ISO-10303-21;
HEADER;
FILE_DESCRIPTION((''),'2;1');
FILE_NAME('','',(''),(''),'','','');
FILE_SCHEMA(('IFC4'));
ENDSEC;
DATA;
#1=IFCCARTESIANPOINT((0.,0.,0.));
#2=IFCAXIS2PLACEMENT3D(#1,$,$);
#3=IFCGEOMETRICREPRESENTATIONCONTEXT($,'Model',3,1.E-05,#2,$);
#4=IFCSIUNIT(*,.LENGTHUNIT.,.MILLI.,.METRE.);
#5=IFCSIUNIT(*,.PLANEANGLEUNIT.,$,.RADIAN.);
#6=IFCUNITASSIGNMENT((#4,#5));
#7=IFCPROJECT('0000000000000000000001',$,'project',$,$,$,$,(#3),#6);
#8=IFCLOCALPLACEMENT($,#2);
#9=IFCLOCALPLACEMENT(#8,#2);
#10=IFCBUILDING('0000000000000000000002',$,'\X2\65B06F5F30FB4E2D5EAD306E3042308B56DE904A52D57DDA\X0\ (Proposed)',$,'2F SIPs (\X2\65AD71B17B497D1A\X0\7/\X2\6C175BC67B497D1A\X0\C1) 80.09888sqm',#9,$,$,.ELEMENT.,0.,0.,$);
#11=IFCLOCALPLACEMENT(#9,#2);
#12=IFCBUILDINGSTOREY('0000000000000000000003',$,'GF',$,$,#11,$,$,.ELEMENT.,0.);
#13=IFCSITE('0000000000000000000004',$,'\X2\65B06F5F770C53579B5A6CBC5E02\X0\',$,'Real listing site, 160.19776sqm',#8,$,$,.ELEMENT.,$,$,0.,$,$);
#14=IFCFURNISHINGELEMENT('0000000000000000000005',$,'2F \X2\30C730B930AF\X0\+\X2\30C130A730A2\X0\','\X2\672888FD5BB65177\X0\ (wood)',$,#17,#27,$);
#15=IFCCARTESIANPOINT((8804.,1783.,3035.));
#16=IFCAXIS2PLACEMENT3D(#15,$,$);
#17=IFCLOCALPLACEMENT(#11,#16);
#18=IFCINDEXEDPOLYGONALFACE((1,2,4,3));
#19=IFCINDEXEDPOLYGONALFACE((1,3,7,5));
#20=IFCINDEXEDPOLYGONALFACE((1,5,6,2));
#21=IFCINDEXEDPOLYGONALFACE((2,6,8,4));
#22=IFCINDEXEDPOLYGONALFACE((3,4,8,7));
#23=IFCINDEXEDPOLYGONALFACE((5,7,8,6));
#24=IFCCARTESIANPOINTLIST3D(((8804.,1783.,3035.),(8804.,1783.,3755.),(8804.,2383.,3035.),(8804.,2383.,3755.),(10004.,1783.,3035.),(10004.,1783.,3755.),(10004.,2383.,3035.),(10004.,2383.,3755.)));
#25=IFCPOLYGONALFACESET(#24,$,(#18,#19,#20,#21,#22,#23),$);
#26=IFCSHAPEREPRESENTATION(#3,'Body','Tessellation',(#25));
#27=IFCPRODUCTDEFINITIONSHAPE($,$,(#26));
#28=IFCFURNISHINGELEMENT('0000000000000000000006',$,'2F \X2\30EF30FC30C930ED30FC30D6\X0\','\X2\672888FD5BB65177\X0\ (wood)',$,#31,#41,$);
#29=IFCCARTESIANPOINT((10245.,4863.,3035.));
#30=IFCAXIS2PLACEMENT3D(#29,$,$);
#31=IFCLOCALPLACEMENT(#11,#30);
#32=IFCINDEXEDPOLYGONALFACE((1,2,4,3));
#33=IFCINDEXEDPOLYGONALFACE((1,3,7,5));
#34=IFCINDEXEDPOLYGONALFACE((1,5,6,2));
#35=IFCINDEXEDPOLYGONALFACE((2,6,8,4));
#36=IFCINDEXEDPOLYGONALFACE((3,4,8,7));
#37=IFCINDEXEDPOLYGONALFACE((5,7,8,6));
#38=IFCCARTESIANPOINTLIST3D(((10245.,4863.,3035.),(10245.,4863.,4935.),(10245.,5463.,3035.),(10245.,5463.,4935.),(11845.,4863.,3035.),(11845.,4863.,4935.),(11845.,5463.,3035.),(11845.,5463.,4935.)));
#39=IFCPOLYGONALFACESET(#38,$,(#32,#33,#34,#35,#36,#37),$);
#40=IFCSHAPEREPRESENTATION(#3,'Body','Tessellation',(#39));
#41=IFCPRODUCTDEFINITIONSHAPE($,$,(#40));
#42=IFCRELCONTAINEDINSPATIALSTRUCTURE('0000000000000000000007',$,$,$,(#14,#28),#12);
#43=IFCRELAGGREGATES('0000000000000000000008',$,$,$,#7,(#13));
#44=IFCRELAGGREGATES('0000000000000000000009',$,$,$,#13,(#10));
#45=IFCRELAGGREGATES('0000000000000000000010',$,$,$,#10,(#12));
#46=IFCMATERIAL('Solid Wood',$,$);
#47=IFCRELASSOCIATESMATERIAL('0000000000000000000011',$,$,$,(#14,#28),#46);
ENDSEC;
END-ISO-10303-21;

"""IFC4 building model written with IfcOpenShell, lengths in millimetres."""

from ifc_helpers import new_model, si_unit, frame, frame_2d, origin, place, context, project, spatial, rectangle, extrude, material, element, save


model = new_model("IFC4")

# Units and contexts
model_context = context("Model", 3, precision=1e-05, world=origin())
ifc_project = project(units=[si_unit("LENGTHUNIT", "METRE", prefix="MILLI"), si_unit("PLANEANGLEUNIT", "RADIAN")], contexts=[model_context])

# Site, building, storey
site_placement = place(None, origin())
site = spatial("IfcSite", under=ifc_project, at=site_placement, Name="新潟県南魚沼市", ObjectType="Real listing site, 160.19776sqm", CompositionType="ELEMENT", RefElevation=0.0)
building_placement = place(site_placement, origin())
building = spatial("IfcBuilding", under=site, at=building_placement, Name="新潟・中庭のある回遊動線 (Proposed)", ObjectType="2F SIPs (断熱等級7/気密等級C1) 80.09888sqm", CompositionType="ELEMENT", ElevationOfRefHeight=0.0, ElevationOfTerrain=0.0)
storey_placement = place(building_placement, origin())
storey = spatial("IfcBuildingStorey", under=building, at=storey_placement, Name="GF", CompositionType="ELEMENT", Elevation=0.0)

# Shared definitions
ifc_material_1 = material(Name="Solid Wood")

# Furnishing elements
furnishing_1_placement = place(storey_placement, frame((8804.0, 1783.0, 3035.0)))
element("IfcFurnishingElement", 1, at=furnishing_1_placement, inside=storey, material=ifc_material_1, Name="2F デスク+チェア", Description="木製家具 (wood)", context=model_context, shape_type="SweptSolid", body=[
    extrude(rectangle(XDim=1200.0, YDim=600.0, at=frame_2d((600.0, 300.0))), frame((8804.0, 1783.0, 3035.0)), (0.0, 0.0, 1.0), 720.0),
])
furnishing_2_placement = place(storey_placement, frame((10245.0, 4863.0, 3035.0)))
element("IfcFurnishingElement", 2, at=furnishing_2_placement, inside=storey, material=ifc_material_1, Name="2F ワードローブ", Description="木製家具 (wood)", context=model_context, shape_type="SweptSolid", body=[
    extrude(rectangle(XDim=1600.0, YDim=600.0, at=frame_2d((800.0, 300.0))), frame((10245.0, 4863.0, 3035.0)), (0.0, 0.0, 1.0), 1900.0),
])

save(model, "model.ifc")
